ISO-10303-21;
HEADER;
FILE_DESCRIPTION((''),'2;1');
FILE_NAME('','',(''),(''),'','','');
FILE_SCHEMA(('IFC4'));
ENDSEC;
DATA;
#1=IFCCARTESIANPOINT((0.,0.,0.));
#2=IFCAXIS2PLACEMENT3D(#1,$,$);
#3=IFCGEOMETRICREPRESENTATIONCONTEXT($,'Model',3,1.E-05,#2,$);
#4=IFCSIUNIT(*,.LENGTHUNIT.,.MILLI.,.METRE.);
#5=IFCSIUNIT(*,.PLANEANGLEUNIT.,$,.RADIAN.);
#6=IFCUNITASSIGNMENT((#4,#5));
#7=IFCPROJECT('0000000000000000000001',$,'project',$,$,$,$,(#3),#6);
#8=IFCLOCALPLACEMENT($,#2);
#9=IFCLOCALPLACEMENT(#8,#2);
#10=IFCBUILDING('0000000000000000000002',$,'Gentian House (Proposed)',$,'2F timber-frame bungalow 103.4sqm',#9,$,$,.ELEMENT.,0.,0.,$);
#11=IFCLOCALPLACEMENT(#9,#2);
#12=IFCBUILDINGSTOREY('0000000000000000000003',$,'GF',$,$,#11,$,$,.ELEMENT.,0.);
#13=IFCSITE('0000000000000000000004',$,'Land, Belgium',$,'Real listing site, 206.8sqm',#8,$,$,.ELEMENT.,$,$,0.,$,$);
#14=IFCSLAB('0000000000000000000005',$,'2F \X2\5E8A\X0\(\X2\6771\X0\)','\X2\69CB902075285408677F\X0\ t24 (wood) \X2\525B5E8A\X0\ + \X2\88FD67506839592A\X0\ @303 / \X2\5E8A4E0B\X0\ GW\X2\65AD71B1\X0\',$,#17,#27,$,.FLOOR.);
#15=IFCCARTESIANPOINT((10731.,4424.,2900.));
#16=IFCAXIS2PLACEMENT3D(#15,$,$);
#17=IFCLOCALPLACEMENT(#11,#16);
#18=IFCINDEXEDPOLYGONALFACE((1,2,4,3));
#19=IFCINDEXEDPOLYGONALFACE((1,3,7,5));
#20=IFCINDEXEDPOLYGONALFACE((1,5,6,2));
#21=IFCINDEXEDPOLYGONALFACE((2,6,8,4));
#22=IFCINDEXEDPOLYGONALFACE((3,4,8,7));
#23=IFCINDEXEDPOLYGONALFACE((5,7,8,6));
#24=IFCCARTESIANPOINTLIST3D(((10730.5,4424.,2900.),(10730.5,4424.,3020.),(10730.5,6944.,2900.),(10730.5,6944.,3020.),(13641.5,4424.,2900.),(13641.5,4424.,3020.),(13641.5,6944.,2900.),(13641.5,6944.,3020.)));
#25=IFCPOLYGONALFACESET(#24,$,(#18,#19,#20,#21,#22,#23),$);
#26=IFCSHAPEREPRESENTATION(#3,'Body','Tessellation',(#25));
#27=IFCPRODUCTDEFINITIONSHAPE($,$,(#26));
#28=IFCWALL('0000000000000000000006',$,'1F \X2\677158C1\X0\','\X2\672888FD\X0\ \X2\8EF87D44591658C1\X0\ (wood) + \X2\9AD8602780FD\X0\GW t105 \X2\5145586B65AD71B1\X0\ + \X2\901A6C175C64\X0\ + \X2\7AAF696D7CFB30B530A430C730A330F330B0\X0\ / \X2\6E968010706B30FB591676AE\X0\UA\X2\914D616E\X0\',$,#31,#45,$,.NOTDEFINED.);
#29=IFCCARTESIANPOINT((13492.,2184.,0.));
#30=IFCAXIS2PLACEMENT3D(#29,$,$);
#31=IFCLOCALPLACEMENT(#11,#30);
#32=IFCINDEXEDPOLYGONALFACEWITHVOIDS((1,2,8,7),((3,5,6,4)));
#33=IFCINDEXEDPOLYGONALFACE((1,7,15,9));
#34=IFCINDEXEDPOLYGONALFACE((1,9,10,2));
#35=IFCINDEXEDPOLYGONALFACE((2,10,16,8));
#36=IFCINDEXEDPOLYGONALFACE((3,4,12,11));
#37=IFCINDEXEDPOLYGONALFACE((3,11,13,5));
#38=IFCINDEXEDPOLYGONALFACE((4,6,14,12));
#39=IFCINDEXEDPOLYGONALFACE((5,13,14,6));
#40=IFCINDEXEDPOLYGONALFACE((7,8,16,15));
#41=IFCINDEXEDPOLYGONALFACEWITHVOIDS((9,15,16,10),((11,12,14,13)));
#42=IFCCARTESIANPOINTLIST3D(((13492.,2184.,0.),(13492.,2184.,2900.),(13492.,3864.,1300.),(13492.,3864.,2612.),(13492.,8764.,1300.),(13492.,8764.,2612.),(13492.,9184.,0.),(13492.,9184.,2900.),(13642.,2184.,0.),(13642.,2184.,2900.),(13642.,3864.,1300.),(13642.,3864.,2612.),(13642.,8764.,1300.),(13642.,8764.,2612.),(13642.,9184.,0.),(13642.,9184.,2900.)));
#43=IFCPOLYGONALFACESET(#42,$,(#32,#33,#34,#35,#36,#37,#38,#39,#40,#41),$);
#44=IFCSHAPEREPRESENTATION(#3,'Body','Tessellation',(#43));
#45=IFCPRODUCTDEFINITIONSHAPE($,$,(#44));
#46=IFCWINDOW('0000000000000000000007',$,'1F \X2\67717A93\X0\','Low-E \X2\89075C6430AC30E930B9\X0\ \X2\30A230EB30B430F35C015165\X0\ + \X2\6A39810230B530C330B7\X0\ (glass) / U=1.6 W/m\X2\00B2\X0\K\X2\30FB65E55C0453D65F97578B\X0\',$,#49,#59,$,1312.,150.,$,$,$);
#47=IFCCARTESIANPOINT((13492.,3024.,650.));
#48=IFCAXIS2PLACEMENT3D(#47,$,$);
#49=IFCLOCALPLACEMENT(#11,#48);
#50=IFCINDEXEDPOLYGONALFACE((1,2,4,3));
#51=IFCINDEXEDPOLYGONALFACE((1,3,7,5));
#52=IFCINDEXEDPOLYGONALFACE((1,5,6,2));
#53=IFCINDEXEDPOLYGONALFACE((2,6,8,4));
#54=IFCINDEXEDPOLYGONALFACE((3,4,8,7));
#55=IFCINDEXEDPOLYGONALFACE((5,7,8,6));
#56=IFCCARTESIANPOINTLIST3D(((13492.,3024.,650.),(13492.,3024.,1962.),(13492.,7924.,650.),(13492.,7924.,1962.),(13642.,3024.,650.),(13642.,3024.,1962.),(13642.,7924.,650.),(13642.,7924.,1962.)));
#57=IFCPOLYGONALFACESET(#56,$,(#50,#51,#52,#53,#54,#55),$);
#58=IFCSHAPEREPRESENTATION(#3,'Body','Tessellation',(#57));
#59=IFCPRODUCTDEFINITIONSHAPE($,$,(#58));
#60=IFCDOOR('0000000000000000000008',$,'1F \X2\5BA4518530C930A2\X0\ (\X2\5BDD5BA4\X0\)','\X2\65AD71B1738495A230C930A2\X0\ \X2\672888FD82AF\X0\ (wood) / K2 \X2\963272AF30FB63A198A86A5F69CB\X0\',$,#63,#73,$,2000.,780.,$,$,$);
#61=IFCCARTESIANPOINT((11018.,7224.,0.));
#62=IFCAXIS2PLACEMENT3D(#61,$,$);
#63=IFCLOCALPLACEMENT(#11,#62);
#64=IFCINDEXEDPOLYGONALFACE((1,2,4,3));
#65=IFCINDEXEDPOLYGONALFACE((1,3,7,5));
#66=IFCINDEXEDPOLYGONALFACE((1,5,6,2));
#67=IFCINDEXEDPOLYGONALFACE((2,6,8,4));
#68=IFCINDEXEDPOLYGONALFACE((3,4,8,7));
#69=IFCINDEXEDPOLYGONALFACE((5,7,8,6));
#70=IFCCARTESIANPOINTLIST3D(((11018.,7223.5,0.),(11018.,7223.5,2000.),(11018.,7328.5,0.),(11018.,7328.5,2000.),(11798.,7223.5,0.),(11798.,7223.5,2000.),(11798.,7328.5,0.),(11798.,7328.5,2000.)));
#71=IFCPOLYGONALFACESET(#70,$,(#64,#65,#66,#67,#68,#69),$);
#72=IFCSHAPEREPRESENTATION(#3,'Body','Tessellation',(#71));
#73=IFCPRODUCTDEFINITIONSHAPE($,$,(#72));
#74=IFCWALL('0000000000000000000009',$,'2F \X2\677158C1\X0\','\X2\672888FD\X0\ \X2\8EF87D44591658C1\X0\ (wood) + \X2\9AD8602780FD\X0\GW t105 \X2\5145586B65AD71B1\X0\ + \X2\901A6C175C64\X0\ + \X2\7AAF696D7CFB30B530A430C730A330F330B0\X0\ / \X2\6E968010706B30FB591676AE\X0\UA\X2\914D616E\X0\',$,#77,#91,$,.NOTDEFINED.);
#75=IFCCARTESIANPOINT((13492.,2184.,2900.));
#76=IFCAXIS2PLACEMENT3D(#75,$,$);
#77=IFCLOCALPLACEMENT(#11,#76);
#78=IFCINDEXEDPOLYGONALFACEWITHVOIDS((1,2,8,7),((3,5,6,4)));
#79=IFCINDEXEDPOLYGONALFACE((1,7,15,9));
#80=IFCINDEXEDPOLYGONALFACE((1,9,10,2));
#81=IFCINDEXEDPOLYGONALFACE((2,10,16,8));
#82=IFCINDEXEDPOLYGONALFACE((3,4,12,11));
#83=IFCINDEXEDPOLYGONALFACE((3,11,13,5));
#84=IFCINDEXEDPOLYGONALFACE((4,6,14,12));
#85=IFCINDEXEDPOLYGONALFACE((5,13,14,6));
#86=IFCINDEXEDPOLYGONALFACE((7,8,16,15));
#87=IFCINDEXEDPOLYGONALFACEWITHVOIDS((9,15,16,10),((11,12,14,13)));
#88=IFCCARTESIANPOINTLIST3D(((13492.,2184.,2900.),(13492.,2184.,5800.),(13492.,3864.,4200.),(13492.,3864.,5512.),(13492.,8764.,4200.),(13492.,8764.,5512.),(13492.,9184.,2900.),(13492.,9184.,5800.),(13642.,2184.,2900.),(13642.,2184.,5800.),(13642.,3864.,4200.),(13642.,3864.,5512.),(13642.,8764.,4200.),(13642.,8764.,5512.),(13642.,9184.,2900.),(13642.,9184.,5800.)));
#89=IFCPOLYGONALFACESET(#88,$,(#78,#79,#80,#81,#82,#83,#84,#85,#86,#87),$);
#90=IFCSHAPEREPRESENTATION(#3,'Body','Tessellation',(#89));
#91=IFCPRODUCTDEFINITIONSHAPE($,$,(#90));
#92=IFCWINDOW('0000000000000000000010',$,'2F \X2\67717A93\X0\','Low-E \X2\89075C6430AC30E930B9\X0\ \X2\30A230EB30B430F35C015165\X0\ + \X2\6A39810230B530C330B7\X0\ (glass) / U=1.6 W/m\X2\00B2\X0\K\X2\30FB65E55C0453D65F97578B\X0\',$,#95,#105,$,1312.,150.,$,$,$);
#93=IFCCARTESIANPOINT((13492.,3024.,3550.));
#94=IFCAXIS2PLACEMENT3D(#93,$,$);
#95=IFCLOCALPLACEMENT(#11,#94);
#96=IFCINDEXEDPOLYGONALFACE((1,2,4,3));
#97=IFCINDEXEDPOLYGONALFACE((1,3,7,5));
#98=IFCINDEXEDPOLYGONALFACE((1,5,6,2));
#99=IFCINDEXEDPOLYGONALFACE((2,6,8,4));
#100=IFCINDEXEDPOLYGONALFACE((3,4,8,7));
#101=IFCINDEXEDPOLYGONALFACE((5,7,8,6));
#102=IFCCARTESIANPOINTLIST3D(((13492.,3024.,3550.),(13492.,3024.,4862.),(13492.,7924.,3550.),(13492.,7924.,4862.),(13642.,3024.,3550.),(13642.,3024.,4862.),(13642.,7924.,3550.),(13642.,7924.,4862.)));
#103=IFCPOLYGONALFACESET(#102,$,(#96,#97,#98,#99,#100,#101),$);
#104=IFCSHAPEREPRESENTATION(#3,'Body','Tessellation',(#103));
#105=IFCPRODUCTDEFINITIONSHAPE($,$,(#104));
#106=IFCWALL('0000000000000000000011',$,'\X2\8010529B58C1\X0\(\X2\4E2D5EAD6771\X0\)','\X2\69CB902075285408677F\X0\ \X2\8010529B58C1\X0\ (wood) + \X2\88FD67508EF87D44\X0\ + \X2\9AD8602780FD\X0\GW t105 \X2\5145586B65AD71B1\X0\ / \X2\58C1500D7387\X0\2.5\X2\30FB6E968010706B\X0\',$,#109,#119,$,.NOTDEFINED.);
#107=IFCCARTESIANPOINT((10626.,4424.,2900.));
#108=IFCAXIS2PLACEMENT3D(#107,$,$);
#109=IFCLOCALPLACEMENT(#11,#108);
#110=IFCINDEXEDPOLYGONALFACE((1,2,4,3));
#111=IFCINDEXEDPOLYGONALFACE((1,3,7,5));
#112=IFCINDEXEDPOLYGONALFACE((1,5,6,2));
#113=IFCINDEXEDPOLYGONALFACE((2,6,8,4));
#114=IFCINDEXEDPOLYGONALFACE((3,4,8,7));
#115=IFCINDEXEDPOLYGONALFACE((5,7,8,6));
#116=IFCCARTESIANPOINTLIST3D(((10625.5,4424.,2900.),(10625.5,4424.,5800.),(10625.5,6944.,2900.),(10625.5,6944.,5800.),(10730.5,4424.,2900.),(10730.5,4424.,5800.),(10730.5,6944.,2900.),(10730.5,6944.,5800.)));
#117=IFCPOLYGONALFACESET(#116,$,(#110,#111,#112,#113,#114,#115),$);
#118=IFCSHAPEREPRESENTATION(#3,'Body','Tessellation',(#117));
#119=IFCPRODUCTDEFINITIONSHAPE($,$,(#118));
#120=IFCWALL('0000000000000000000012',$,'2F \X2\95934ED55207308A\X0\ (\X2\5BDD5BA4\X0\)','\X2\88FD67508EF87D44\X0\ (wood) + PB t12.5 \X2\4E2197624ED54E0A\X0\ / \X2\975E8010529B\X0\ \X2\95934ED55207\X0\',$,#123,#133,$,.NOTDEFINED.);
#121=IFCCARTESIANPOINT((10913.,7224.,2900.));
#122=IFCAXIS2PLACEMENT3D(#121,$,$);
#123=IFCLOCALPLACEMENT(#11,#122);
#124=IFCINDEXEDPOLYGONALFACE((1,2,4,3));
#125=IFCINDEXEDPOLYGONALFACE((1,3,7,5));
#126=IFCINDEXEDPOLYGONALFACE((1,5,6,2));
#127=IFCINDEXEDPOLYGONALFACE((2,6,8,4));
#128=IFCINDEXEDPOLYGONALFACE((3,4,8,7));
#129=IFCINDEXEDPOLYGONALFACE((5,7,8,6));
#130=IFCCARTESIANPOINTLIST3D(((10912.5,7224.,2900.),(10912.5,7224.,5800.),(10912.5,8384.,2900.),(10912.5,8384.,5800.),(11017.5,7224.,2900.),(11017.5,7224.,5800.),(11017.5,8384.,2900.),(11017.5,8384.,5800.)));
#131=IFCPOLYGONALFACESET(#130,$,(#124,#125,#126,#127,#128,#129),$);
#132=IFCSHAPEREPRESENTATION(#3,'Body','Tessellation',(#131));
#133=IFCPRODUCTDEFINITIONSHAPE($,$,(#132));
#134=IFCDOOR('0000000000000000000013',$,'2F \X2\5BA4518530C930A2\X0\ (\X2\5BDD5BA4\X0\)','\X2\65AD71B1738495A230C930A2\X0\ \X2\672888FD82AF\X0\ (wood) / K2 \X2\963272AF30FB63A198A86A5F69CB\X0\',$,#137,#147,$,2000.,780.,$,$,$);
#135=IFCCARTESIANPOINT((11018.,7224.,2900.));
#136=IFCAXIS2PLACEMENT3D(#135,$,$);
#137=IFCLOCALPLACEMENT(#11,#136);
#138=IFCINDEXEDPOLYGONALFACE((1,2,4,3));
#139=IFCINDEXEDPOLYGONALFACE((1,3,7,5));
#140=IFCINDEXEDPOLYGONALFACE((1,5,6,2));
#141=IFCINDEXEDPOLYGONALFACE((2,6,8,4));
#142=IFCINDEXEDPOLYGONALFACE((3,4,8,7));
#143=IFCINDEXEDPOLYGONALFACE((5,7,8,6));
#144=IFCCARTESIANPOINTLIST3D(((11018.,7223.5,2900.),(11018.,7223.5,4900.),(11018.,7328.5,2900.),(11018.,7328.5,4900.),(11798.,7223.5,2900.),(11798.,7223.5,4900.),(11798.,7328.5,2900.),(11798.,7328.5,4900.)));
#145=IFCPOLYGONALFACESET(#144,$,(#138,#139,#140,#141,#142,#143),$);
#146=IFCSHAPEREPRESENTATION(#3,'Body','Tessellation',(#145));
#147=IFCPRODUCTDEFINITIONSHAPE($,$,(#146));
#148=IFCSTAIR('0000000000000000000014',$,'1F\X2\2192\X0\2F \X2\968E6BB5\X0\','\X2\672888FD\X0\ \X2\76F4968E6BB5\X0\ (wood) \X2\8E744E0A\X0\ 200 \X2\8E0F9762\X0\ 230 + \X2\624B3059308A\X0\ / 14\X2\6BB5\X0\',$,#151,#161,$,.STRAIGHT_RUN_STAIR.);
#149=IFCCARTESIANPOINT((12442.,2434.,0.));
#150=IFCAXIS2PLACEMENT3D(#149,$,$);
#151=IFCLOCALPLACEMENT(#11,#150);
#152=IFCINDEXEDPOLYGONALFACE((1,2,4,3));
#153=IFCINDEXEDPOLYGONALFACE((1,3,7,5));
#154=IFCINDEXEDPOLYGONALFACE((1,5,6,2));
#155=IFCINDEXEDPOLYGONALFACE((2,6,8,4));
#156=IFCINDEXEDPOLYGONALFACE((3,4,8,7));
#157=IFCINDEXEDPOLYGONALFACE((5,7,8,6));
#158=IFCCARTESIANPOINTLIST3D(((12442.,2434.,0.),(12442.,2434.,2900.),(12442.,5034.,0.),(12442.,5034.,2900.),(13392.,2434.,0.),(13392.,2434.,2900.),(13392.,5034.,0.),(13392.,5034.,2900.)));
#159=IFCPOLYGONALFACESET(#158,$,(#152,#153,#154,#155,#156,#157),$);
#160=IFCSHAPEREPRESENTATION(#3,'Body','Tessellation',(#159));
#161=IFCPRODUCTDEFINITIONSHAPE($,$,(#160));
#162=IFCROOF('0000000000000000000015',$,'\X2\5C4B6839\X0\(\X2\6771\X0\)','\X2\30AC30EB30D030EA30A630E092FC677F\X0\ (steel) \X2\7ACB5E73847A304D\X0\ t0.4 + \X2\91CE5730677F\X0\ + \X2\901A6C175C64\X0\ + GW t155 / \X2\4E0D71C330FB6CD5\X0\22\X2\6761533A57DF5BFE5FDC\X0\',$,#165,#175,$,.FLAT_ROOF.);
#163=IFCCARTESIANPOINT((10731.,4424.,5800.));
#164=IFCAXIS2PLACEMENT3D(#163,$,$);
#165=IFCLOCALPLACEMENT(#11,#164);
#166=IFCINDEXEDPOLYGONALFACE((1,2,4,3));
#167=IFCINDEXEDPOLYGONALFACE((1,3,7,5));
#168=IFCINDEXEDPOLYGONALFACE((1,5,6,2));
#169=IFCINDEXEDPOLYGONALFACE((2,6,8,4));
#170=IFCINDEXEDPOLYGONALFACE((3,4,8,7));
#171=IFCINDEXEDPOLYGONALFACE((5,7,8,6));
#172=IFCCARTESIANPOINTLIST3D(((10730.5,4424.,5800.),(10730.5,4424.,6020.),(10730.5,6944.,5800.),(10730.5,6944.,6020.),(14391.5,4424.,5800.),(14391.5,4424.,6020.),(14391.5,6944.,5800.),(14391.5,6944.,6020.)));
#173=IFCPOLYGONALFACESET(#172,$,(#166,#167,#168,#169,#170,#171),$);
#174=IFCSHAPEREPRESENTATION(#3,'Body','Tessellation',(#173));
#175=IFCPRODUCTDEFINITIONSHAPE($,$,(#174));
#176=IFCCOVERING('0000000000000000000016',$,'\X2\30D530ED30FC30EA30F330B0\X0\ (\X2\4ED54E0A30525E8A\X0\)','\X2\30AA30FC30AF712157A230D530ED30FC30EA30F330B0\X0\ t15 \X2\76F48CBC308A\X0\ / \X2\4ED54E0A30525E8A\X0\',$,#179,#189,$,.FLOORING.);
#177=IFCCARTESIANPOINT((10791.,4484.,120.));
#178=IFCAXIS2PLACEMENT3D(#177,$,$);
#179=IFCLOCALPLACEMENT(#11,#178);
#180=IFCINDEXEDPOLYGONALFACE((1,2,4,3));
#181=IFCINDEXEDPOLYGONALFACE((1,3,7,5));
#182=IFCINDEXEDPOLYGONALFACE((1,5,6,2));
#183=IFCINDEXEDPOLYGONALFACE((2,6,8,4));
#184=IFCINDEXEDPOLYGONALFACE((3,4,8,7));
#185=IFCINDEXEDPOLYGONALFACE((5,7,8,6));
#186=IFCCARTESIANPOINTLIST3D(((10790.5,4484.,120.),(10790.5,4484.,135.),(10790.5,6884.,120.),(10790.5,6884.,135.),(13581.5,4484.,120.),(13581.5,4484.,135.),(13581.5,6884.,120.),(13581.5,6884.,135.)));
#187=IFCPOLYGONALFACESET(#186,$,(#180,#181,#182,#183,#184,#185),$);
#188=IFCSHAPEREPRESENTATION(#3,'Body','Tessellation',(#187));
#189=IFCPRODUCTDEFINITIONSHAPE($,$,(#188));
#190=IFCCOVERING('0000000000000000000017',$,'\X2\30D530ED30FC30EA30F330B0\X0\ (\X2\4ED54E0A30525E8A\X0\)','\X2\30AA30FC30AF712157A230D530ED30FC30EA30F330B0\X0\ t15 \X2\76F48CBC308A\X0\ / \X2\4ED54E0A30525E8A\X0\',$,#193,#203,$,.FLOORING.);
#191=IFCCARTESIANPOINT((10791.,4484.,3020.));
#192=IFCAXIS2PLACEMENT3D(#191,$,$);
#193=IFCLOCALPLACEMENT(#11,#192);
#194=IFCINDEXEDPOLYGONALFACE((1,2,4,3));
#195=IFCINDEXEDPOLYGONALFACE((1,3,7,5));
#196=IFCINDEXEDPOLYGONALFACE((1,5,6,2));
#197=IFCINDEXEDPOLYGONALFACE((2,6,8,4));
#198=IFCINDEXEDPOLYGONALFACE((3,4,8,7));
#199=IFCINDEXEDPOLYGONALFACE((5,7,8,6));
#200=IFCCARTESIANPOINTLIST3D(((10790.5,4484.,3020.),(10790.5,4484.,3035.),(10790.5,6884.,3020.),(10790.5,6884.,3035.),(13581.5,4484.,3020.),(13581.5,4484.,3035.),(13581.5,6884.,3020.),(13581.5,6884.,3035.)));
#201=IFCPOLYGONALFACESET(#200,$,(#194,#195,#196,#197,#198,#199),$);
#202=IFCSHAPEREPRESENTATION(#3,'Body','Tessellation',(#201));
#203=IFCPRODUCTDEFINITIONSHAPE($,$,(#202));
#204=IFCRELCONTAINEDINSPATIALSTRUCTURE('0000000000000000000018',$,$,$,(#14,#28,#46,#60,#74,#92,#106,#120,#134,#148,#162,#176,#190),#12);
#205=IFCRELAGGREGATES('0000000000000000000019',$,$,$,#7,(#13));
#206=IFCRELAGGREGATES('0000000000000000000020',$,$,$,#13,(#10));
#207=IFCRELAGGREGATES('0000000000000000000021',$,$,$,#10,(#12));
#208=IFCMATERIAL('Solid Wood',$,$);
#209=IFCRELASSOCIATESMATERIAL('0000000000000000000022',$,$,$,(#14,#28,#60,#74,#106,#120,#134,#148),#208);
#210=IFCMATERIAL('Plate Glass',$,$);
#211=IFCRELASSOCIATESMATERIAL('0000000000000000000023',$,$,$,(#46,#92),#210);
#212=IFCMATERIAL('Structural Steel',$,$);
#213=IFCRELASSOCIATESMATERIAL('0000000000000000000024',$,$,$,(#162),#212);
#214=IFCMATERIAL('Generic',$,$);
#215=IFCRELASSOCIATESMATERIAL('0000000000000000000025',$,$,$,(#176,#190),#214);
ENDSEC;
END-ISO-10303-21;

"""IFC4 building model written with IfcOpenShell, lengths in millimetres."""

from ifc_helpers import new_model, si_unit, frame, frame_2d, origin, place, context, project, spatial, rectangle, extrude, material, element, fill, save


model = new_model("IFC4")

# Units and contexts
model_context = context("Model", 3, precision=1e-05, world=origin())
ifc_project = project(units=[si_unit("LENGTHUNIT", "METRE", prefix="MILLI"), si_unit("PLANEANGLEUNIT", "RADIAN")], contexts=[model_context])

# Site, building, storey
site_placement = place(None, origin())
site = spatial("IfcSite", under=ifc_project, at=site_placement, Name="Land, Belgium", ObjectType="Real listing site, 206.8sqm", CompositionType="ELEMENT", RefElevation=0.0)
building_placement = place(site_placement, origin())
building = spatial("IfcBuilding", under=site, at=building_placement, Name="Gentian House (Proposed)", ObjectType="2F timber-frame bungalow 103.4sqm", CompositionType="ELEMENT", ElevationOfRefHeight=0.0, ElevationOfTerrain=0.0)
storey_placement = place(building_placement, origin())
storey = spatial("IfcBuildingStorey", under=building, at=storey_placement, Name="GF", CompositionType="ELEMENT", Elevation=0.0)

# Slab
ifc_material_1 = material(Name="Solid Wood")
slab_1_placement = place(storey_placement, frame((10731.0, 4424.0, 2900.0)))
element("IfcSlab", 1, at=slab_1_placement, inside=storey, material=ifc_material_1, Name="2F 床(東)", Description="構造用合板 t24 (wood) 剛床 + 製材根太 @303 / 床下 GW断熱", PredefinedType="FLOOR", context=model_context, shape_type="SweptSolid", body=[
    extrude(rectangle(XDim=2911.0, YDim=2520.0, at=frame_2d((1455.0, 1260.0))), frame((10731.0, 4424.0, 2900.0)), (0.0, 0.0, 1.0), 120.0),
])

# Wall, opening, window
wall_1_placement = place(storey_placement, frame((13492.0, 2184.0, 0.0)))
wall_1 = element("IfcWall", 2, at=wall_1_placement, inside=storey, material=ifc_material_1, Name="1F 東壁", Description="木製 軸組外壁 (wood) + 高性能GW t105 充填断熱 + 通気層 + 窯業系サイディング / 準耐火・外皮UA配慮", PredefinedType="NOTDEFINED", context=model_context, shape_type="SweptSolid", body=[
    extrude(rectangle(XDim=150.0, YDim=7000.0, at=frame_2d((75.0, 3500.0))), frame((13492.0, 2184.0, 0.0)), (0.0, 0.0, 1.0), 2900.0),
])
opening_1_placement = place(storey_placement, frame((13492.0, 3024.0, 650.0)))
opening_1 = element("IfcOpeningElement", 3, at=opening_1_placement, cuts=wall_1, PredefinedType="NOTDEFINED", context=model_context, shape_type="SweptSolid", body=[
    extrude(rectangle(XDim=150.0, YDim=4900.0, at=frame_2d((75.0, 2450.0))), frame((13492.0, 3024.0, 650.0)), (0.0, 0.0, 1.0), 1312.0),
])
ifc_material_2 = material(Name="Plate Glass")
window_1_placement = place(storey_placement, frame((13492.0, 3024.0, 650.0)))
window_1 = element("IfcWindow", 4, at=window_1_placement, inside=storey, material=ifc_material_2, Name="1F 東窓", Description="Low-E 複層ガラス アルゴン封入 + 樹脂サッシ (glass) / U=1.6 W/m²K・日射取得型", OverallHeight=1312.0, OverallWidth=150.0, context=model_context, shape_type="SweptSolid", body=[
    extrude(rectangle(XDim=150.0, YDim=4900.0, at=frame_2d((75.0, 2450.0))), frame((13492.0, 3024.0, 650.0)), (0.0, 0.0, 1.0), 1312.0),
])
fill(opening_1, window_1)

# Door
door_1_placement = place(storey_placement, frame((11018.0, 7224.0, 0.0)))
element("IfcDoor", 5, at=door_1_placement, inside=storey, material=ifc_material_1, Name="1F 室内ドア (寝室)", Description="断熱玄関ドア 木製芯 (wood) / K2 防犯・採風機構", OverallHeight=2000.0, OverallWidth=780.0, context=model_context, shape_type="SweptSolid", body=[
    extrude(rectangle(XDim=780.0, YDim=105.0, at=frame_2d((390.0, 52.0))), frame((11018.0, 7224.0, 0.0)), (0.0, 0.0, 1.0), 2000.0),
])

# Wall, opening, window
wall_2_placement = place(storey_placement, frame((13492.0, 2184.0, 2900.0)))
wall_2 = element("IfcWall", 6, at=wall_2_placement, inside=storey, material=ifc_material_1, Name="2F 東壁", Description="木製 軸組外壁 (wood) + 高性能GW t105 充填断熱 + 通気層 + 窯業系サイディング / 準耐火・外皮UA配慮", PredefinedType="NOTDEFINED", context=model_context, shape_type="SweptSolid", body=[
    extrude(rectangle(XDim=150.0, YDim=7000.0, at=frame_2d((75.0, 3500.0))), frame((13492.0, 2184.0, 2900.0)), (0.0, 0.0, 1.0), 2900.0),
])
opening_2_placement = place(storey_placement, frame((13492.0, 3024.0, 3550.0)))
opening_2 = element("IfcOpeningElement", 7, at=opening_2_placement, cuts=wall_2, PredefinedType="NOTDEFINED", context=model_context, shape_type="SweptSolid", body=[
    extrude(rectangle(XDim=150.0, YDim=4900.0, at=frame_2d((75.0, 2450.0))), frame((13492.0, 3024.0, 3550.0)), (0.0, 0.0, 1.0), 1312.0),
])
window_2_placement = place(storey_placement, frame((13492.0, 3024.0, 3550.0)))
window_2 = element("IfcWindow", 8, at=window_2_placement, inside=storey, material=ifc_material_2, Name="2F 東窓", Description="Low-E 複層ガラス アルゴン封入 + 樹脂サッシ (glass) / U=1.6 W/m²K・日射取得型", OverallHeight=1312.0, OverallWidth=150.0, context=model_context, shape_type="SweptSolid", body=[
    extrude(rectangle(XDim=150.0, YDim=4900.0, at=frame_2d((75.0, 2450.0))), frame((13492.0, 3024.0, 3550.0)), (0.0, 0.0, 1.0), 1312.0),
])
fill(opening_2, window_2)

# Walls
wall_3_placement = place(storey_placement, frame((10626.0, 4424.0, 2900.0)))
element("IfcWall", 9, at=wall_3_placement, inside=storey, material=ifc_material_1, Name="耐力壁(中庭東)", Description="構造用合板 耐力壁 (wood) + 製材軸組 + 高性能GW t105 充填断熱 / 壁倍率2.5・準耐火", PredefinedType="NOTDEFINED", context=model_context, shape_type="SweptSolid", body=[
    extrude(rectangle(XDim=105.0, YDim=2520.0, at=frame_2d((52.0, 1260.0))), frame((10626.0, 4424.0, 2900.0)), (0.0, 0.0, 1.0), 2900.0),
])
wall_4_placement = place(storey_placement, frame((10913.0, 7224.0, 2900.0)))
element("IfcWall", 10, at=wall_4_placement, inside=storey, material=ifc_material_1, Name="2F 間仕切り (寝室)", Description="製材軸組 (wood) + PB t12.5 両面仕上 / 非耐力 間仕切", PredefinedType="NOTDEFINED", context=model_context, shape_type="SweptSolid", body=[
    extrude(rectangle(XDim=105.0, YDim=1160.0, at=frame_2d((52.0, 580.0))), frame((10913.0, 7224.0, 2900.0)), (0.0, 0.0, 1.0), 2900.0),
])

# Door
door_2_placement = place(storey_placement, frame((11018.0, 7224.0, 2900.0)))
element("IfcDoor", 11, at=door_2_placement, inside=storey, material=ifc_material_1, Name="2F 室内ドア (寝室)", Description="断熱玄関ドア 木製芯 (wood) / K2 防犯・採風機構", OverallHeight=2000.0, OverallWidth=780.0, context=model_context, shape_type="SweptSolid", body=[
    extrude(rectangle(XDim=780.0, YDim=105.0, at=frame_2d((390.0, 52.0))), frame((11018.0, 7224.0, 2900.0)), (0.0, 0.0, 1.0), 2000.0),
])

# Stair
stair_placement = place(storey_placement, frame((12442.0, 2434.0, 0.0)))
element("IfcStair", 12, at=stair_placement, inside=storey, material=ifc_material_1, Name="1F→2F 階段", Description="木製 直階段 (wood) 蹴上 200 踏面 230 + 手すり / 14段", PredefinedType="STRAIGHT_RUN_STAIR", context=model_context, shape_type="SweptSolid", body=[
    extrude(rectangle(XDim=950.0, YDim=2600.0, at=frame_2d((475.0, 1300.0))), frame((12442.0, 2434.0, 0.0)), (0.0, 0.0, 1.0), 2900.0),
])

# Roof
ifc_material_3 = material(Name="Structural Steel")
for number, where, name in (
    (13, (10731.0, 4424.0, 5800.0), "屋根(東)"),
):
    element("IfcRoof", number, at=place(storey_placement, frame(where)), inside=storey, material=ifc_material_3, Name=name, Description="ガルバリウム鋼板 (steel) 立平葺き t0.4 + 野地板 + 通気層 + GW t155 / 不燃・法22条区域対応", PredefinedType="FLAT_ROOF", context=model_context, shape_type="SweptSolid", body=[
        extrude(rectangle(XDim=3661.0, YDim=2520.0, at=frame_2d((1830.0, 1260.0))), frame((10731.0, 4424.0, 5800.0)), (0.0, 0.0, 1.0), 220.0),
    ])

# Coverings
ifc_material_4 = material(Name="Generic")
covering_1_placement = place(storey_placement, frame((10791.0, 4484.0, 120.0)))
element("IfcCovering", 14, at=covering_1_placement, inside=storey, material=ifc_material_4, Name="フローリング (仕上げ床)", Description="オーク無垢フローリング t15 直貼り / 仕上げ床", PredefinedType="FLOORING", context=model_context, shape_type="SweptSolid", body=[
    extrude(rectangle(XDim=2791.0, YDim=2400.0, at=frame_2d((1395.0, 1200.0))), frame((10791.0, 4484.0, 120.0)), (0.0, 0.0, 1.0), 15.0),
])
covering_2_placement = place(storey_placement, frame((10791.0, 4484.0, 3020.0)))
element("IfcCovering", 15, at=covering_2_placement, inside=storey, material=ifc_material_4, Name="フローリング (仕上げ床)", Description="オーク無垢フローリング t15 直貼り / 仕上げ床", PredefinedType="FLOORING", context=model_context, shape_type="SweptSolid", body=[
    extrude(rectangle(XDim=2791.0, YDim=2400.0, at=frame_2d((1395.0, 1200.0))), frame((10791.0, 4484.0, 3020.0)), (0.0, 0.0, 1.0), 15.0),
])

save(model, "model.ifc")
